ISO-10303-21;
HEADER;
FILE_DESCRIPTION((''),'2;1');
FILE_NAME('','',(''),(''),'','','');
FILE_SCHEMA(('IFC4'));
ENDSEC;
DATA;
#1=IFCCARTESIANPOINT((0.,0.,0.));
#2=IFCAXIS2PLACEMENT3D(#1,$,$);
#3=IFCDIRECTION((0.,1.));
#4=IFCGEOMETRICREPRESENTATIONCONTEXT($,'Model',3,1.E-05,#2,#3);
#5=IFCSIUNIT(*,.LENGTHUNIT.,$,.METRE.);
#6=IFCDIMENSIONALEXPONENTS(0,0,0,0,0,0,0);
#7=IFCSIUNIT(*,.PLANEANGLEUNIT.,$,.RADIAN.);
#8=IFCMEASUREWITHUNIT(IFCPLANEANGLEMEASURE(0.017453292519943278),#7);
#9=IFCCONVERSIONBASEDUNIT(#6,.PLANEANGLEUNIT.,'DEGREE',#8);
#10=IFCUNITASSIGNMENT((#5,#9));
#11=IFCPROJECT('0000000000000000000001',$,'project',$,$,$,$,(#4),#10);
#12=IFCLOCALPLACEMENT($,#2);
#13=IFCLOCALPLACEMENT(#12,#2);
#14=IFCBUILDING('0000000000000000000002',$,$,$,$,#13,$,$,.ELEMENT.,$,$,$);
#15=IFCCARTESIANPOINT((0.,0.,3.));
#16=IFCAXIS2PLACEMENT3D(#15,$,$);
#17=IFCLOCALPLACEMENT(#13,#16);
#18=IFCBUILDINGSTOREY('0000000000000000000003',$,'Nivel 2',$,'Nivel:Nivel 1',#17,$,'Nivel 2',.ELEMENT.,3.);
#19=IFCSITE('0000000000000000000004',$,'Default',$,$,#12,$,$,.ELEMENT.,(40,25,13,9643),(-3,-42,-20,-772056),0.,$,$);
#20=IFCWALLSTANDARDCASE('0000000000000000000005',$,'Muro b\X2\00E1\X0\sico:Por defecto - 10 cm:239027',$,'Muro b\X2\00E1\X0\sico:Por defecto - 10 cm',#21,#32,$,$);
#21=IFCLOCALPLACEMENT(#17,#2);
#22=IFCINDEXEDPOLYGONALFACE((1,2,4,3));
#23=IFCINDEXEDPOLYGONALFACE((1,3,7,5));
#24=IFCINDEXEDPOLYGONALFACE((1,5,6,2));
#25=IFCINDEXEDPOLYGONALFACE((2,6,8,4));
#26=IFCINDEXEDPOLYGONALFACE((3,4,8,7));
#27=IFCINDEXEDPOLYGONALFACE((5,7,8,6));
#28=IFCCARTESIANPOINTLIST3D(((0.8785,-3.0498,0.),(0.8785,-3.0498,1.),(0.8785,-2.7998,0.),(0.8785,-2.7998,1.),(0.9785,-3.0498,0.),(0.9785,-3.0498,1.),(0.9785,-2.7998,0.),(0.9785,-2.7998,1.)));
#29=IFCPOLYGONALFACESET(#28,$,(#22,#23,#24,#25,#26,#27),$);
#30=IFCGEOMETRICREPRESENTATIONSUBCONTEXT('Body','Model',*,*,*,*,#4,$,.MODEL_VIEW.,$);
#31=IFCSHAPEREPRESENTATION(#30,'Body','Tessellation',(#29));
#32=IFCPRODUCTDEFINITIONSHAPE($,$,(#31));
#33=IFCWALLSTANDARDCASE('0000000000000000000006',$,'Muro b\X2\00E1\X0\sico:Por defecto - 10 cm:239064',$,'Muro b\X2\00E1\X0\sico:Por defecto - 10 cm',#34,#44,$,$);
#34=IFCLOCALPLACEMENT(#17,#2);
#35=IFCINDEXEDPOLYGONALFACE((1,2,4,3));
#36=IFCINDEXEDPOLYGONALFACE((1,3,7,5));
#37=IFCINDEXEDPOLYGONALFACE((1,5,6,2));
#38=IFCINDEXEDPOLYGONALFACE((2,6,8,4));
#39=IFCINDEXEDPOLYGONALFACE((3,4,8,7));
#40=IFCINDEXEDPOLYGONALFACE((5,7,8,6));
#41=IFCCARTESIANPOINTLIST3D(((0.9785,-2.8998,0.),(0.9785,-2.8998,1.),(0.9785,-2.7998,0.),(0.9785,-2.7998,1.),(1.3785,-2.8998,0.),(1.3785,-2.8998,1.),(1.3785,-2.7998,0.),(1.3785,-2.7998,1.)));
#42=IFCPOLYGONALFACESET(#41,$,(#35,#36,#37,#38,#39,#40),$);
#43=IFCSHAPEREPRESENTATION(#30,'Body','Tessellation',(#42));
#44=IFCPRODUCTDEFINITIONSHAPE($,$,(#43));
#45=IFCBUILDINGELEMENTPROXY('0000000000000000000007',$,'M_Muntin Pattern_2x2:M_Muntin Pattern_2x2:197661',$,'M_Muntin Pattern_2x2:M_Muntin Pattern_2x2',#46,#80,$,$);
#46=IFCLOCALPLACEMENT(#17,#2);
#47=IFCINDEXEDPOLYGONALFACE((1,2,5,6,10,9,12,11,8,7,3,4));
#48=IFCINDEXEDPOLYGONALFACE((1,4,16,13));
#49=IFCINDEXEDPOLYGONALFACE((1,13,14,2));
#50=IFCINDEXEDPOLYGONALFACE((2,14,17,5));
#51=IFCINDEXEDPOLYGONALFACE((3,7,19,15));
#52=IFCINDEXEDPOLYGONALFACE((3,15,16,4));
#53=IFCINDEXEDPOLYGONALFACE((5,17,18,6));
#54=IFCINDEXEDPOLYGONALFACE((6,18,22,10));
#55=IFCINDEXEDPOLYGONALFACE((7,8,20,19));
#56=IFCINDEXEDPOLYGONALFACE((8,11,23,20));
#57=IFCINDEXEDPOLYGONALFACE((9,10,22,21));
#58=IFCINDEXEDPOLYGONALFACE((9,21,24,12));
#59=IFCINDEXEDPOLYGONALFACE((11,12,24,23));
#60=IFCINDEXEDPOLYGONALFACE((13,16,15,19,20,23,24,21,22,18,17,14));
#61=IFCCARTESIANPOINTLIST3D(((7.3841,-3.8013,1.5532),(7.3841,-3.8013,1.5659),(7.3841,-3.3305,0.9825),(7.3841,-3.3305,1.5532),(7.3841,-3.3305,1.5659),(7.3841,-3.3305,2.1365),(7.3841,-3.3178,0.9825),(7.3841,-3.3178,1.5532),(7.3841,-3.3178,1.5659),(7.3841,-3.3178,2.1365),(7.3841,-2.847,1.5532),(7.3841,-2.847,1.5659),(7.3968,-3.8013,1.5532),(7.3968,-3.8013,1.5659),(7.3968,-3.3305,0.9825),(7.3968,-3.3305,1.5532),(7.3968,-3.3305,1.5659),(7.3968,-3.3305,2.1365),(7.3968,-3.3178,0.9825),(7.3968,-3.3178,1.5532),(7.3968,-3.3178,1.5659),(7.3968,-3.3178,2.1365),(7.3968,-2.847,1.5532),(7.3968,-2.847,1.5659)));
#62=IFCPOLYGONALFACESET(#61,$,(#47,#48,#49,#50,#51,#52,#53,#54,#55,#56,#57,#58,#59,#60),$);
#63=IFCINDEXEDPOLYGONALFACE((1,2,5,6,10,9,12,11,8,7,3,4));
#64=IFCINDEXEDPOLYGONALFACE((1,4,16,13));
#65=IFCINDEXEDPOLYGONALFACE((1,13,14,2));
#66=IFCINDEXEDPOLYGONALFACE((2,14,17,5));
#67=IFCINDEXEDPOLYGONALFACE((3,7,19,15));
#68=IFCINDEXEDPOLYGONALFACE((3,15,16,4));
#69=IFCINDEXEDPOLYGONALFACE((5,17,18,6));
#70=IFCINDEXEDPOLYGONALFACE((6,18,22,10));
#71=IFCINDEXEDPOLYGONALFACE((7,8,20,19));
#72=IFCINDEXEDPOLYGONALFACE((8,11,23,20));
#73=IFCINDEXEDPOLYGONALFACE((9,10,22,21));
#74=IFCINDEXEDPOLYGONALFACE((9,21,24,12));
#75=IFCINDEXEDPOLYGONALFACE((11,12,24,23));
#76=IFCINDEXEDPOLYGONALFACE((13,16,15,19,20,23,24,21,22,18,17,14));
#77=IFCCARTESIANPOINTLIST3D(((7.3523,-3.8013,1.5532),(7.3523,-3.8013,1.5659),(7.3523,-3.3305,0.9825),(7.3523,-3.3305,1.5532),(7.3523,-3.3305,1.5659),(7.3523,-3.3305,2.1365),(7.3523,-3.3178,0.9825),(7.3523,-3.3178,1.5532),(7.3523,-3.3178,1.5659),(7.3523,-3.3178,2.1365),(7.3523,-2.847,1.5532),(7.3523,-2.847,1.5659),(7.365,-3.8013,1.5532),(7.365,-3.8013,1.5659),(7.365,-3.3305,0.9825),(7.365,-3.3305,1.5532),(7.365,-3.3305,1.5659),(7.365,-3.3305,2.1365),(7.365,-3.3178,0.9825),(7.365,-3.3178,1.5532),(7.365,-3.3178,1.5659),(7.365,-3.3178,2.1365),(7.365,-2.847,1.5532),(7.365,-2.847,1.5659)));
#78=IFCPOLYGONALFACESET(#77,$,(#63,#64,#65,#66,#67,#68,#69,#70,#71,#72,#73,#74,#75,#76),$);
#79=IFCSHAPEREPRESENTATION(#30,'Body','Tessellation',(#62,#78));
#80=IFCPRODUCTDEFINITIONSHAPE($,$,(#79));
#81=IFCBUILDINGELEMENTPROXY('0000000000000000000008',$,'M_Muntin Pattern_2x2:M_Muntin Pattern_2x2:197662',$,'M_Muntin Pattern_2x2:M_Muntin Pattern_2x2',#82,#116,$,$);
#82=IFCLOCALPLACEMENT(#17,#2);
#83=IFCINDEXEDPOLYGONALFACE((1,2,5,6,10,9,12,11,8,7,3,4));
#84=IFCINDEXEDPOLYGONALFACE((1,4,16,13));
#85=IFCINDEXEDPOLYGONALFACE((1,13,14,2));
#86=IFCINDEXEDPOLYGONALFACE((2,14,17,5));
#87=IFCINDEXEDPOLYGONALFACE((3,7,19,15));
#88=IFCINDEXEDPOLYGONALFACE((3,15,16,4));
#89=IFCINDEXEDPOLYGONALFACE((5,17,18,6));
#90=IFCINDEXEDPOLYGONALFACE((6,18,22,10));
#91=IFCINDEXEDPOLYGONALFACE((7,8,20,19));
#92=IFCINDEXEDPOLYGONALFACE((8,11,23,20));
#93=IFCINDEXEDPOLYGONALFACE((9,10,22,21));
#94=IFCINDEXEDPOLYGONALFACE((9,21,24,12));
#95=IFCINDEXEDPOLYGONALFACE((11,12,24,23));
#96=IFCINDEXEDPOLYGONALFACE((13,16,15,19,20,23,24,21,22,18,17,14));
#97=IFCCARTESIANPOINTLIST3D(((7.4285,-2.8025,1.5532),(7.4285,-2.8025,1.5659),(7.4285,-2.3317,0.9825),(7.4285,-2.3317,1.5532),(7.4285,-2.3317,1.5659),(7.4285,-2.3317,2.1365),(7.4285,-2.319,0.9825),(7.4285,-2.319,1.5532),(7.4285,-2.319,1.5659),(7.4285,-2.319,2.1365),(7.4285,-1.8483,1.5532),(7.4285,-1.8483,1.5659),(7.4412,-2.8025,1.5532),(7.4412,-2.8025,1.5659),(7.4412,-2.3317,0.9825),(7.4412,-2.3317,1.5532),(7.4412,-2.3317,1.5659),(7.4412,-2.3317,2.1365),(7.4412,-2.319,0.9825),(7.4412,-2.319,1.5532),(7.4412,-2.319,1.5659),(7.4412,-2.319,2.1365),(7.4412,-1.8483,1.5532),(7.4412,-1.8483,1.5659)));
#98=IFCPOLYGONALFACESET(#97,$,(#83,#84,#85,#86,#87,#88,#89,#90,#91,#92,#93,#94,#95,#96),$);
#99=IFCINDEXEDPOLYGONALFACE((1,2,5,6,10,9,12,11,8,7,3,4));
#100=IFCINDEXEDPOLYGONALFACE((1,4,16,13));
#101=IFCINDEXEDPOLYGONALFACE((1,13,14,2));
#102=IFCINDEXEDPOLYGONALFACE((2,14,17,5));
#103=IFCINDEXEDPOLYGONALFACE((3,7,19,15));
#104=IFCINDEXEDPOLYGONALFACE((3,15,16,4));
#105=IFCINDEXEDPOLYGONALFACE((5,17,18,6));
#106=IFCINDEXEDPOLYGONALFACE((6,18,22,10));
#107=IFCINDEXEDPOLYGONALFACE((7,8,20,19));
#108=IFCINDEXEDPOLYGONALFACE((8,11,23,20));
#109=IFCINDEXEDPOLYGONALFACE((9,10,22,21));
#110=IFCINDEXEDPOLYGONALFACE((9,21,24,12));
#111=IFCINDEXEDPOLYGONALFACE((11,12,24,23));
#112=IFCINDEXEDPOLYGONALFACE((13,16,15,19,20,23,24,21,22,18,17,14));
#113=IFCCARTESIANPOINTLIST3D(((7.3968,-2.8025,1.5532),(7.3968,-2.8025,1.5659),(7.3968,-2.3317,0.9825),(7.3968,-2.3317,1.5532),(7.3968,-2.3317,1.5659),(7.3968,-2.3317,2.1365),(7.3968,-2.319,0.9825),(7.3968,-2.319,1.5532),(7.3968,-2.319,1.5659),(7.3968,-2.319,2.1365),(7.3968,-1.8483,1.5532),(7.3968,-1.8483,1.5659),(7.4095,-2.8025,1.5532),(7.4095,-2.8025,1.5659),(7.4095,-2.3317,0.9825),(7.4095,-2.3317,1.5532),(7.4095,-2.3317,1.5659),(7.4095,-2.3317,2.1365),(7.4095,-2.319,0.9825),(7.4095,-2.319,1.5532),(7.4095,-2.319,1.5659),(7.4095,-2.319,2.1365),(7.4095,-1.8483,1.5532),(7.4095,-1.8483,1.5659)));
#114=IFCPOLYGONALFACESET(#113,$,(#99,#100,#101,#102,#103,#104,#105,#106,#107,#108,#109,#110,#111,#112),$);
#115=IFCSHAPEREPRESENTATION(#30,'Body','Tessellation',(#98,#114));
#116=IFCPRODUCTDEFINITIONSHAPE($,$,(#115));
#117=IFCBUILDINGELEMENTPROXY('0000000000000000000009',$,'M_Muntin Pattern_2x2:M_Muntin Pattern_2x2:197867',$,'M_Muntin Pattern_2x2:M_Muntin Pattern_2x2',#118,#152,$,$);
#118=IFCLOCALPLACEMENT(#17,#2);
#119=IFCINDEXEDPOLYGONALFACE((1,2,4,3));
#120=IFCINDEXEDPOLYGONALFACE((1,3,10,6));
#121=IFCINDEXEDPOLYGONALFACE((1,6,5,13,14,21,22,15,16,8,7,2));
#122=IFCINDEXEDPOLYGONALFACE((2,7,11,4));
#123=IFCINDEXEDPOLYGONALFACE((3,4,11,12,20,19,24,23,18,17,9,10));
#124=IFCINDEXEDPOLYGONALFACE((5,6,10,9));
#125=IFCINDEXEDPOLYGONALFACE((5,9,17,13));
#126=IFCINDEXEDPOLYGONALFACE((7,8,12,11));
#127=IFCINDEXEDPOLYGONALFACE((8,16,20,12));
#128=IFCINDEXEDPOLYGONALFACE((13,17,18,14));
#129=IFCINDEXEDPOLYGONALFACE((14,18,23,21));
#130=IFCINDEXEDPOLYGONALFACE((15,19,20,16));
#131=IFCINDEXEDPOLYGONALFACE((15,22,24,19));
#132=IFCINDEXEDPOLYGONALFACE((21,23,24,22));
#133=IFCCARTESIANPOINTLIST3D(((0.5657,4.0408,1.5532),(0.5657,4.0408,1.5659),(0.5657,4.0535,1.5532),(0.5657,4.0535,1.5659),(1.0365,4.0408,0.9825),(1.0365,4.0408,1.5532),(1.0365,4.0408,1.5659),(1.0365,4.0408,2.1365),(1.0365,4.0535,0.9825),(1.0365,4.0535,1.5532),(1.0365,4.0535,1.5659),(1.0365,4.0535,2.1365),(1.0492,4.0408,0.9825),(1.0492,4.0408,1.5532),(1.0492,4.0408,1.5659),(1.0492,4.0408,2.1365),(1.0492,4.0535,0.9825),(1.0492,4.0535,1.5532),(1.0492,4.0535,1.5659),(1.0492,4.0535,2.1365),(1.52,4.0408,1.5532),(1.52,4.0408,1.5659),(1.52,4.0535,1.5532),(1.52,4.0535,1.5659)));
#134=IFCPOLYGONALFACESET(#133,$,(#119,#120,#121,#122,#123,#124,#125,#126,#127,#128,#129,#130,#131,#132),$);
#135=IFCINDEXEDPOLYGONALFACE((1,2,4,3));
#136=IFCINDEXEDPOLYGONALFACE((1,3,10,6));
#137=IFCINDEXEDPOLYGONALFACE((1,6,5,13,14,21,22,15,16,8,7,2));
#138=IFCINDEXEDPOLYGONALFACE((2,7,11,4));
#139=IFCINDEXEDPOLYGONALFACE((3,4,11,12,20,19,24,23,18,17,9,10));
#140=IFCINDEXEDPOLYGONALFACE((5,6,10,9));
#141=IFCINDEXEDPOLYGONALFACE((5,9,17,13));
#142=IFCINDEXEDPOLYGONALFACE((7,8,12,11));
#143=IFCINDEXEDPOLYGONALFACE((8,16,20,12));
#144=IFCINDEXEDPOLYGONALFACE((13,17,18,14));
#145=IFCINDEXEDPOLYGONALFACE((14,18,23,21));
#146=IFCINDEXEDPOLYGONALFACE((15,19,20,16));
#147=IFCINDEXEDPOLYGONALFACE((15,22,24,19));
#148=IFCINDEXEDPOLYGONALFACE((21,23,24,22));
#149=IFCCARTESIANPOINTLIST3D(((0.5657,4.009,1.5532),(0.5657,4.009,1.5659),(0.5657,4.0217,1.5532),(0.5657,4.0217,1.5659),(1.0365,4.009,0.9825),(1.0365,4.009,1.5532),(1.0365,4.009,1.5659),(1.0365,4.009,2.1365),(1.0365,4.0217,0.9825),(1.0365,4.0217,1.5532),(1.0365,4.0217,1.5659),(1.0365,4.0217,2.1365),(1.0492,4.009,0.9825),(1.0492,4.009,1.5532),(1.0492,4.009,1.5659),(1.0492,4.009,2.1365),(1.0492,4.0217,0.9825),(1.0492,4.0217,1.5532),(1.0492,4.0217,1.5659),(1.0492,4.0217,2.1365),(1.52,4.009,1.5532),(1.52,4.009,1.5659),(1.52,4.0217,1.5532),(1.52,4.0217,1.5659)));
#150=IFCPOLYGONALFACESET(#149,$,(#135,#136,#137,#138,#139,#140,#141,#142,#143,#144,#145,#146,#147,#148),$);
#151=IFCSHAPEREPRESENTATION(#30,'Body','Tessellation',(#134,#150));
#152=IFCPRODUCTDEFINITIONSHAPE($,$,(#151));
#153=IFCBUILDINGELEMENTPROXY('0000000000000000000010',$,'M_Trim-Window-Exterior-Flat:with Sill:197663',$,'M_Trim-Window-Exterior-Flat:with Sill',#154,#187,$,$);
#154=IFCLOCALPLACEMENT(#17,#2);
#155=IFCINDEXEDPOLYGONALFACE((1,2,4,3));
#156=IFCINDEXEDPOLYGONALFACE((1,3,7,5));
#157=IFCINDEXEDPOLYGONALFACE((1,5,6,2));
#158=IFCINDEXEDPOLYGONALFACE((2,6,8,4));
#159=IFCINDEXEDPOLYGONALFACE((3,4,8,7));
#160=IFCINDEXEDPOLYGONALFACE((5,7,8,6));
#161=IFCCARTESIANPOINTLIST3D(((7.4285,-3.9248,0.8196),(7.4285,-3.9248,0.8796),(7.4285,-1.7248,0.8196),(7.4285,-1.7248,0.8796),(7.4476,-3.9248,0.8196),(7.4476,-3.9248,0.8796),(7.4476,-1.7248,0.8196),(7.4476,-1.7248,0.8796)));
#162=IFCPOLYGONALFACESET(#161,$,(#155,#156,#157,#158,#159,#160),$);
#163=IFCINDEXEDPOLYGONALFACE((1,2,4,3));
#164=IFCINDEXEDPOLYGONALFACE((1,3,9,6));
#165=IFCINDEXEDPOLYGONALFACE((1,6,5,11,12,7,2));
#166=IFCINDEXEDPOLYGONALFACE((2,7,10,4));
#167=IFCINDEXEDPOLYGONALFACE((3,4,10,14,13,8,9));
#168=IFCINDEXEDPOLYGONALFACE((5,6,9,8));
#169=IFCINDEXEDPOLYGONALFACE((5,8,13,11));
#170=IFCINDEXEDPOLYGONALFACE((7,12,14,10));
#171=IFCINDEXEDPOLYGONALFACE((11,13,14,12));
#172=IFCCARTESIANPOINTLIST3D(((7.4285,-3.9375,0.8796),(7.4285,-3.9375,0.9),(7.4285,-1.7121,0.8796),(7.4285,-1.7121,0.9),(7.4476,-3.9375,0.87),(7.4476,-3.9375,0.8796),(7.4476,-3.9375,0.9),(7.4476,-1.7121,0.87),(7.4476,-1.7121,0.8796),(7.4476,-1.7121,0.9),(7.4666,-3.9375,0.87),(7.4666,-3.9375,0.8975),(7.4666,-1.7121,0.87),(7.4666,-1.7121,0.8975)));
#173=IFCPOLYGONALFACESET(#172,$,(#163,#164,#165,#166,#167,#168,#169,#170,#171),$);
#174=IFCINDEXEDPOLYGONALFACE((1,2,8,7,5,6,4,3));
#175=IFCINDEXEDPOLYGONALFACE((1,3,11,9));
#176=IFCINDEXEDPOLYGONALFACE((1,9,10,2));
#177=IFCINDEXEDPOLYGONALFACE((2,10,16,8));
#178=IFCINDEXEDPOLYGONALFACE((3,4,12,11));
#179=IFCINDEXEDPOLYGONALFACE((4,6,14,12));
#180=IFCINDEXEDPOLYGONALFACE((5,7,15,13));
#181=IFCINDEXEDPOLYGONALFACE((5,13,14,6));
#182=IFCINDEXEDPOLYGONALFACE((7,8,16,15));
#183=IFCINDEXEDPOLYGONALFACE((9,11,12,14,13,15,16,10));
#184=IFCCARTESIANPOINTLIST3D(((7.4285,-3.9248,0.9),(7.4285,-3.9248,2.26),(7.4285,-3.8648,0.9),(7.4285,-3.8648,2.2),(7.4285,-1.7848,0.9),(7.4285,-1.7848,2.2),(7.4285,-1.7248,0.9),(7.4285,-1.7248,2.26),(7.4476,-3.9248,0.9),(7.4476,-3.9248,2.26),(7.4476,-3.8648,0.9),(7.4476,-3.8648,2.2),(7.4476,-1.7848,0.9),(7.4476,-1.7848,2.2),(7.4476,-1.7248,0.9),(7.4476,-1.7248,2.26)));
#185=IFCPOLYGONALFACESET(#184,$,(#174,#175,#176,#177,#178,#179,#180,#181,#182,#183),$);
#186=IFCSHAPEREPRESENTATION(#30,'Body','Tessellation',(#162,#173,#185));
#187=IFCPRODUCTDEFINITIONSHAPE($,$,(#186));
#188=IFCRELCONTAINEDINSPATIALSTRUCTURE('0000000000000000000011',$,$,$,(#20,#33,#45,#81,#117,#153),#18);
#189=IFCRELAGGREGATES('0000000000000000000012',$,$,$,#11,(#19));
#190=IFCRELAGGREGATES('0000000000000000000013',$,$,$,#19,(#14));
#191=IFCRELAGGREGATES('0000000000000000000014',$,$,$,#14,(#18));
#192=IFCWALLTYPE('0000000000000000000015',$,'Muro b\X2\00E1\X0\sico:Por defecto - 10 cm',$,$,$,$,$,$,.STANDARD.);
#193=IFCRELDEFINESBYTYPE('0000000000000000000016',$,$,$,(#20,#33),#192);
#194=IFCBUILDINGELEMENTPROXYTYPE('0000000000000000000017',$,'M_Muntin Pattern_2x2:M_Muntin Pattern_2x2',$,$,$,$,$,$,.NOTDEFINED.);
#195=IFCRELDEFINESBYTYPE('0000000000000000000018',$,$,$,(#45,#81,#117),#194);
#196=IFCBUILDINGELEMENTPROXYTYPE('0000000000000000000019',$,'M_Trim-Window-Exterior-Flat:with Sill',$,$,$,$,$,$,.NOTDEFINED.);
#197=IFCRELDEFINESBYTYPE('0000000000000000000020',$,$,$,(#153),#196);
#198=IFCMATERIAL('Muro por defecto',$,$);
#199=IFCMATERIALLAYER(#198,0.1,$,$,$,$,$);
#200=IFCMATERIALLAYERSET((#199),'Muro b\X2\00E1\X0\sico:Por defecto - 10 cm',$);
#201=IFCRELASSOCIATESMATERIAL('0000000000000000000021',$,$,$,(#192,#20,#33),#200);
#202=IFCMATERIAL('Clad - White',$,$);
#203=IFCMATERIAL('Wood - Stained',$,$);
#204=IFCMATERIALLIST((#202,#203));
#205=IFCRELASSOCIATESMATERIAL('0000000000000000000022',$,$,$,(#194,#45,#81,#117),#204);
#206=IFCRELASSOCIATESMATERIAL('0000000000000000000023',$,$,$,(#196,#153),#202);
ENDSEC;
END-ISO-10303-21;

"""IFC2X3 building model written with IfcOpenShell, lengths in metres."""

from ifc_helpers import new_model, entity, si_unit, converted_unit, direction, frame, frame_2d, origin, place, context, subcontext, project, spatial, polyline, rectangle, outline, extrude, source, transform, mapped, material, material_list, layer, layer_set, layer_usage, type_object, type_shapes, element, save


model = new_model("IFC2X3")

# Units and contexts
model_context = context("Model", 3, precision=1e-05, world=origin(), true_north=direction((0.0, 1.0)))
body_context = subcontext(model_context, "Body", "Model", "MODEL_VIEW")
ifc_project = project(units=[si_unit("LENGTHUNIT", "METRE"), converted_unit("PLANEANGLEUNIT", "DEGREE", entity("IfcPlaneAngleMeasure", 0.017453292519943278), si_unit("PLANEANGLEUNIT", "RADIAN"), dimensions=[0, 0, 0, 0, 0, 0, 0])], contexts=[model_context])

# Site, building, storey
site_placement = place(None, origin())
site = spatial("IfcSite", under=ifc_project, at=site_placement, Name="Default", CompositionType="ELEMENT", RefLatitude=(40, 25, 13, 9643), RefLongitude=(-3, -42, -20, -772056), RefElevation=0.0)
building_placement = place(site_placement, origin())
building = spatial("IfcBuilding", under=site, at=building_placement, CompositionType="ELEMENT")
storey_placement = place(building_placement, frame((0.0, 0.0, 3.0)))
storey = spatial("IfcBuildingStorey", under=building, at=storey_placement, Name="Nivel 2", ObjectType="Nivel:Nivel 1", LongName="Nivel 2", CompositionType="ELEMENT", Elevation=3.0)

# Shared definitions
ifc_material_1 = material(Name="Muro por defecto")

# Walls
ifc_layer_1 = layer(ifc_material_1, 0.1)
ifc_layer_set_1 = layer_set([ifc_layer_1], Name="Muro básico:Por defecto - 10 cm")
wall_type_1 = type_object("IfcWallType", Name="Muro básico:Por defecto - 10 cm", PredefinedType="STANDARD", material=ifc_layer_set_1)
ifc_layer_usage_1 = layer_usage(ifc_layer_set_1, "AXIS2", "POSITIVE", -0.05)
wall_1_placement = place(storey_placement, frame((0.9285, -3.0498, 0.0), z_axis=(0.0, 0.0, 1.0), x_axis=(0.0, 1.0, 0.0)))
element("IfcWallStandardCase", 1, at=wall_1_placement, inside=storey, type_object=wall_type_1, material=ifc_layer_usage_1, Name="Muro básico:Por defecto - 10 cm:239027", ObjectType="Muro básico:Por defecto - 10 cm", context=body_context, shape_type="SweptSolid", body=[
    extrude(rectangle(XDim=0.25, YDim=0.1, at=frame_2d((0.125, 0.0), x_axis=(-1.0, 0.0))), origin(), (0.0, 0.0, 1.0), 1.0),
])
ifc_layer_usage_2 = layer_usage(ifc_layer_set_1, "AXIS2", "POSITIVE", -0.05)
wall_2_placement = place(storey_placement, frame((0.9785, -2.8498, 0.0)))
element("IfcWallStandardCase", 2, at=wall_2_placement, inside=storey, type_object=wall_type_1, material=ifc_layer_usage_2, Name="Muro básico:Por defecto - 10 cm:239064", ObjectType="Muro básico:Por defecto - 10 cm", context=body_context, shape_type="SweptSolid", body=[
    extrude(rectangle(XDim=0.4, YDim=0.1, at=frame_2d((0.2, 0.0), x_axis=(-1.0, 0.0))), origin(), (0.0, 0.0, 1.0), 1.0),
])

# Building element proxies
ifc_material_2 = material(Name="Clad - White")
ifc_material_3 = material(Name="Wood - Stained")
ifc_material_list_1 = material_list([ifc_material_2, ifc_material_3])
building_element_proxy_type_1 = type_object("IfcBuildingElementProxyType", Name="M_Muntin Pattern_2x2:M_Muntin Pattern_2x2", PredefinedType="NOTDEFINED", material=ifc_material_list_1)
shared_shape_1 = source(origin(), body_context, "Body", "SweptSolid", [
    extrude(outline(polyline([(0.0064, -0.0064), (0.577, -0.0064), (0.577, 0.0063), (0.0064, 0.0063), (0.0064, 0.4771), (-0.0063, 0.4771), (-0.0063, 0.0063), (-0.577, 0.0063), (-0.577, -0.0064), (-0.0063, -0.0064), (-0.0063, -0.4771), (0.0064, -0.4771), (0.0064, -0.0064)])), frame((0.0, 0.0095, 0.577), z_axis=(0.0, 1.0, 0.0), x_axis=(0.0, 0.0, 1.0)), (0.0, 0.0, 1.0), 0.0127),
    extrude(outline(polyline([(0.0064, -0.0064), (0.577, -0.0064), (0.577, 0.0063), (0.0064, 0.0063), (0.0064, 0.4771), (-0.0063, 0.4771), (-0.0063, 0.0063), (-0.577, 0.0063), (-0.577, -0.0064), (-0.0063, -0.0064), (-0.0063, -0.4771), (0.0064, -0.4771), (0.0064, -0.0064)])), frame((0.0, -0.0222, 0.577), z_axis=(0.0, 1.0, 0.0), x_axis=(0.0, 0.0, 1.0)), (0.0, 0.0, 1.0), 0.0127),
])
type_shapes(building_element_proxy_type_1, [shared_shape_1])
for number, where, z_axis, x_axis, name in (
    (3, (7.3745, -3.3241, 0.9825), (0.0, 0.0, 1.0), (0.0, -1.0, 0.0), "M_Muntin Pattern_2x2:M_Muntin Pattern_2x2:197661"),
    (4, (7.419, -2.3254, 0.9825), (0.0, 0.0, 1.0), (0.0, -1.0, 0.0), "M_Muntin Pattern_2x2:M_Muntin Pattern_2x2:197662"),
):
    element("IfcBuildingElementProxy", number, at=place(storey_placement, frame(where, z_axis=z_axis, x_axis=x_axis)), inside=storey, type_object=building_element_proxy_type_1, material=ifc_material_list_1, Name=name, ObjectType="M_Muntin Pattern_2x2:M_Muntin Pattern_2x2", context=body_context, shape_type="MappedRepresentation", body=[
        mapped(shared_shape_1, transform((0.0, 0.0, 0.0), scale=1.0)),
    ])
proxy_placement = place(storey_placement, frame((1.0429, 4.0313, 0.9825)))
element("IfcBuildingElementProxy", 5, at=proxy_placement, inside=storey, type_object=building_element_proxy_type_1, material=ifc_material_list_1, Name="M_Muntin Pattern_2x2:M_Muntin Pattern_2x2:197867", ObjectType="M_Muntin Pattern_2x2:M_Muntin Pattern_2x2", context=body_context, shape_type="MappedRepresentation", body=[
    mapped(shared_shape_1, transform((0.0, 0.0, 0.0), scale=1.0)),
])
building_element_proxy_type_2 = type_object("IfcBuildingElementProxyType", Name="M_Trim-Window-Exterior-Flat:with Sill", PredefinedType="NOTDEFINED", material=ifc_material_2)
shared_shape_2 = source(origin(), body_context, "Body", "SweptSolid", [
    extrude(rectangle(XDim=2.2, YDim=0.06, at=frame_2d((0.0, 0.0), x_axis=(1.0, 0.0))), frame((0.0, -1.3504, 0.0), z_axis=(0.0, 0.0, 1.0), x_axis=(-1.0, 0.0, 0.0)), (0.0, 0.0, 1.0), 0.019),
    extrude(outline(polyline([(-0.019, -0.0152), (0.0, -0.0152), (0.0, -0.0057), (0.019, -0.0057), (0.019, 0.0148), (0.0, 0.0148), (-0.019, 0.0123), (-0.019, -0.0152)])), frame((-1.1127, -1.3148, 0.019), z_axis=(1.0, 0.0, 0.0), x_axis=(0.0, 0.0, -1.0)), (0.0, 0.0, 1.0), 2.2254),
    extrude(outline(polyline([(-0.695, -1.1), (0.665, -1.1), (0.665, -1.04), (-0.635, -1.04), (-0.635, 1.04), (0.665, 1.04), (0.665, 1.1), (-0.695, 1.1), (-0.695, -1.1)])), frame((0.0, -0.635, 0.0), z_axis=(0.0, 0.0, 1.0), x_axis=(0.0, -1.0, 0.0)), (0.0, 0.0, 1.0), 0.019),
])
type_shapes(building_element_proxy_type_2, [shared_shape_2])
for number, where, z_axis, x_axis, name in (
    (6, (7.4285, -2.8248, 2.2), (1.0, 0.0, 0.0), (0.0, 1.0, 0.0), "M_Trim-Window-Exterior-Flat:with Sill:197663"),
):
    element("IfcBuildingElementProxy", number, at=place(storey_placement, frame(where, z_axis=z_axis, x_axis=x_axis)), inside=storey, type_object=building_element_proxy_type_2, material=ifc_material_2, Name=name, ObjectType="M_Trim-Window-Exterior-Flat:with Sill", context=body_context, shape_type="MappedRepresentation", body=[
        mapped(shared_shape_2, transform((0.0, 0.0, 0.0), scale=1.0)),
    ])

save(model, "model.ifc")
